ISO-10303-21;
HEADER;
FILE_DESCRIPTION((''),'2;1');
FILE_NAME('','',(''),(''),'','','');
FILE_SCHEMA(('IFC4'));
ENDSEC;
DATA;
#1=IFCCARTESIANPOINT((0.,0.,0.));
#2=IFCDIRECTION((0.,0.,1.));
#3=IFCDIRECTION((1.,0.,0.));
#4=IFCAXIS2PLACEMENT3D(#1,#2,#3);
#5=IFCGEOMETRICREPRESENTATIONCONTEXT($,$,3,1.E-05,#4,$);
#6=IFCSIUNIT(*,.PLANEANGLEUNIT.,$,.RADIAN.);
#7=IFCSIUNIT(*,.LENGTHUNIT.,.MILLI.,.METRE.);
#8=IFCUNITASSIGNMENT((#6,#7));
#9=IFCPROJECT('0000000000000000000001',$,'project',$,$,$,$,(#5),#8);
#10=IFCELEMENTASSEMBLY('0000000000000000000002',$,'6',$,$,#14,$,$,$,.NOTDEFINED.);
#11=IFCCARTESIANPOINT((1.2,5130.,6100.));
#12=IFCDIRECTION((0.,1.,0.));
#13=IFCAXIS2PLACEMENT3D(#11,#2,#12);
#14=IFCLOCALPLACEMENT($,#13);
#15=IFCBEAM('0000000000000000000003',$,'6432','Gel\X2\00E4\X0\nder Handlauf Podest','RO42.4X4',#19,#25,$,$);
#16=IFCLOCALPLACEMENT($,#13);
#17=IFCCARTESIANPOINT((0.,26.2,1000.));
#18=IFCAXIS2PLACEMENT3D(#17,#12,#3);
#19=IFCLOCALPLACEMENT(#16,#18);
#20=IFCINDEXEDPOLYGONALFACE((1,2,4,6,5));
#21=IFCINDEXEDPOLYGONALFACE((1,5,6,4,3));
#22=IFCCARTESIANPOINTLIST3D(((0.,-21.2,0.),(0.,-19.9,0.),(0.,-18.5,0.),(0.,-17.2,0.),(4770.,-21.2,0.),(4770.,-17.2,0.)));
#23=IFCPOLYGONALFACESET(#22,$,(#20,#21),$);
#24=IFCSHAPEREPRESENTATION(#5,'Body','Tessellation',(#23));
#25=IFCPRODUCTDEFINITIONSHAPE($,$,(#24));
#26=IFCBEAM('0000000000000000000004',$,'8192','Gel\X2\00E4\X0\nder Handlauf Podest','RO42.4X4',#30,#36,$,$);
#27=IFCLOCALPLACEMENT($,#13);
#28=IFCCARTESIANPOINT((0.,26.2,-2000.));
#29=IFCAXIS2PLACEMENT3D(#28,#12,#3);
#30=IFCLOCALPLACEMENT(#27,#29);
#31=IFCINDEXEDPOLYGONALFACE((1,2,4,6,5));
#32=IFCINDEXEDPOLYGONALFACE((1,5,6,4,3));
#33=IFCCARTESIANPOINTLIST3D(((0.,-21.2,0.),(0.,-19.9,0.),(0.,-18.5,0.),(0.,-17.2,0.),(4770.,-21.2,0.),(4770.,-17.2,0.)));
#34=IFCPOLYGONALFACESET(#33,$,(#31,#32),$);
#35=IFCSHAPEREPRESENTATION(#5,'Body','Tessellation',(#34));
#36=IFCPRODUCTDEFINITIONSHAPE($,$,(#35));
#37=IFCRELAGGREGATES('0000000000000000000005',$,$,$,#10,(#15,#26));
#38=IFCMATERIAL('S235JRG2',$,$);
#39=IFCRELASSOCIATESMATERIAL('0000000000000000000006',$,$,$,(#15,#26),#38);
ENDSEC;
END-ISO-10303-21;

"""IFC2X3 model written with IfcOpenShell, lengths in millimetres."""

from ifc_helpers import new_model, si_unit, frame, origin_with_axes, place, context, project, polyline, outline, extrude, material, element, aggregate, save


model = new_model("IFC2X3")

# Units and contexts
context_of_model = context(None, 3, precision=1e-05, world=origin_with_axes())
ifc_project = project(units=[si_unit("PLANEANGLEUNIT", "RADIAN"), si_unit("LENGTHUNIT", "METRE", prefix="MILLI")], contexts=[context_of_model])

# Shared definitions
ifc_material = material(Name="S235JRG2")

# Element assembly, beams
assembly_1_placement = place(None, frame((1.2, 5130.0, 6100.0), z_axis=(0.0, 0.0, 1.0), x_axis=(0.0, 1.0, 0.0)))
assembly_1 = element("IfcElementAssembly", 1, at=assembly_1_placement, Name="6", PredefinedType="NOTDEFINED")
placement_1 = place(None, frame((1.2, 5130.0, 6100.0), z_axis=(0.0, 0.0, 1.0), x_axis=(0.0, 1.0, 0.0)))
beam_1_placement = place(placement_1, frame((0.0, 26.2, 1000.0), z_axis=(0.0, 1.0, 0.0), x_axis=(1.0, 0.0, 0.0)))
beam_1 = element("IfcBeam", 2, at=beam_1_placement, material=ifc_material, Name="6432", Description="Geländer Handlauf Podest", ObjectType="RO42.4X4", context=context_of_model, shape_type="SweptSolid", body=[
    extrude(outline(polyline([(-21.2, 0.0), (-21.2, 0.0), (-17.2, 0.0), (-17.2, 0.0), (-21.2, 0.0)])), frame((0.0, 0.0, 0.0), z_axis=(1.0, 0.0, 0.0), x_axis=(0.0, 1.0, 0.0)), (0.0, 0.0, 1.0), 4770.0),
])
placement_2 = place(None, frame((1.2, 5130.0, 6100.0), z_axis=(0.0, 0.0, 1.0), x_axis=(0.0, 1.0, 0.0)))
beam_2_placement = place(placement_2, frame((0.0, 26.2, -2000.0), z_axis=(0.0, 1.0, 0.0), x_axis=(1.0, 0.0, 0.0)))
beam_2 = element("IfcBeam", 3, at=beam_2_placement, material=ifc_material, Name="8192", Description="Geländer Handlauf Podest", ObjectType="RO42.4X4", context=context_of_model, shape_type="SweptSolid", body=[
    extrude(outline(polyline([(-21.2, 0.0), (-21.2, 0.0), (-17.2, 0.0), (-17.2, 0.0), (-21.2, 0.0)])), frame((0.0, 0.0, 0.0), z_axis=(1.0, 0.0, 0.0), x_axis=(0.0, 1.0, 0.0)), (0.0, 0.0, 1.0), 4770.0),
])
aggregate(assembly_1, [beam_1, beam_2])

save(model, "model.ifc")
